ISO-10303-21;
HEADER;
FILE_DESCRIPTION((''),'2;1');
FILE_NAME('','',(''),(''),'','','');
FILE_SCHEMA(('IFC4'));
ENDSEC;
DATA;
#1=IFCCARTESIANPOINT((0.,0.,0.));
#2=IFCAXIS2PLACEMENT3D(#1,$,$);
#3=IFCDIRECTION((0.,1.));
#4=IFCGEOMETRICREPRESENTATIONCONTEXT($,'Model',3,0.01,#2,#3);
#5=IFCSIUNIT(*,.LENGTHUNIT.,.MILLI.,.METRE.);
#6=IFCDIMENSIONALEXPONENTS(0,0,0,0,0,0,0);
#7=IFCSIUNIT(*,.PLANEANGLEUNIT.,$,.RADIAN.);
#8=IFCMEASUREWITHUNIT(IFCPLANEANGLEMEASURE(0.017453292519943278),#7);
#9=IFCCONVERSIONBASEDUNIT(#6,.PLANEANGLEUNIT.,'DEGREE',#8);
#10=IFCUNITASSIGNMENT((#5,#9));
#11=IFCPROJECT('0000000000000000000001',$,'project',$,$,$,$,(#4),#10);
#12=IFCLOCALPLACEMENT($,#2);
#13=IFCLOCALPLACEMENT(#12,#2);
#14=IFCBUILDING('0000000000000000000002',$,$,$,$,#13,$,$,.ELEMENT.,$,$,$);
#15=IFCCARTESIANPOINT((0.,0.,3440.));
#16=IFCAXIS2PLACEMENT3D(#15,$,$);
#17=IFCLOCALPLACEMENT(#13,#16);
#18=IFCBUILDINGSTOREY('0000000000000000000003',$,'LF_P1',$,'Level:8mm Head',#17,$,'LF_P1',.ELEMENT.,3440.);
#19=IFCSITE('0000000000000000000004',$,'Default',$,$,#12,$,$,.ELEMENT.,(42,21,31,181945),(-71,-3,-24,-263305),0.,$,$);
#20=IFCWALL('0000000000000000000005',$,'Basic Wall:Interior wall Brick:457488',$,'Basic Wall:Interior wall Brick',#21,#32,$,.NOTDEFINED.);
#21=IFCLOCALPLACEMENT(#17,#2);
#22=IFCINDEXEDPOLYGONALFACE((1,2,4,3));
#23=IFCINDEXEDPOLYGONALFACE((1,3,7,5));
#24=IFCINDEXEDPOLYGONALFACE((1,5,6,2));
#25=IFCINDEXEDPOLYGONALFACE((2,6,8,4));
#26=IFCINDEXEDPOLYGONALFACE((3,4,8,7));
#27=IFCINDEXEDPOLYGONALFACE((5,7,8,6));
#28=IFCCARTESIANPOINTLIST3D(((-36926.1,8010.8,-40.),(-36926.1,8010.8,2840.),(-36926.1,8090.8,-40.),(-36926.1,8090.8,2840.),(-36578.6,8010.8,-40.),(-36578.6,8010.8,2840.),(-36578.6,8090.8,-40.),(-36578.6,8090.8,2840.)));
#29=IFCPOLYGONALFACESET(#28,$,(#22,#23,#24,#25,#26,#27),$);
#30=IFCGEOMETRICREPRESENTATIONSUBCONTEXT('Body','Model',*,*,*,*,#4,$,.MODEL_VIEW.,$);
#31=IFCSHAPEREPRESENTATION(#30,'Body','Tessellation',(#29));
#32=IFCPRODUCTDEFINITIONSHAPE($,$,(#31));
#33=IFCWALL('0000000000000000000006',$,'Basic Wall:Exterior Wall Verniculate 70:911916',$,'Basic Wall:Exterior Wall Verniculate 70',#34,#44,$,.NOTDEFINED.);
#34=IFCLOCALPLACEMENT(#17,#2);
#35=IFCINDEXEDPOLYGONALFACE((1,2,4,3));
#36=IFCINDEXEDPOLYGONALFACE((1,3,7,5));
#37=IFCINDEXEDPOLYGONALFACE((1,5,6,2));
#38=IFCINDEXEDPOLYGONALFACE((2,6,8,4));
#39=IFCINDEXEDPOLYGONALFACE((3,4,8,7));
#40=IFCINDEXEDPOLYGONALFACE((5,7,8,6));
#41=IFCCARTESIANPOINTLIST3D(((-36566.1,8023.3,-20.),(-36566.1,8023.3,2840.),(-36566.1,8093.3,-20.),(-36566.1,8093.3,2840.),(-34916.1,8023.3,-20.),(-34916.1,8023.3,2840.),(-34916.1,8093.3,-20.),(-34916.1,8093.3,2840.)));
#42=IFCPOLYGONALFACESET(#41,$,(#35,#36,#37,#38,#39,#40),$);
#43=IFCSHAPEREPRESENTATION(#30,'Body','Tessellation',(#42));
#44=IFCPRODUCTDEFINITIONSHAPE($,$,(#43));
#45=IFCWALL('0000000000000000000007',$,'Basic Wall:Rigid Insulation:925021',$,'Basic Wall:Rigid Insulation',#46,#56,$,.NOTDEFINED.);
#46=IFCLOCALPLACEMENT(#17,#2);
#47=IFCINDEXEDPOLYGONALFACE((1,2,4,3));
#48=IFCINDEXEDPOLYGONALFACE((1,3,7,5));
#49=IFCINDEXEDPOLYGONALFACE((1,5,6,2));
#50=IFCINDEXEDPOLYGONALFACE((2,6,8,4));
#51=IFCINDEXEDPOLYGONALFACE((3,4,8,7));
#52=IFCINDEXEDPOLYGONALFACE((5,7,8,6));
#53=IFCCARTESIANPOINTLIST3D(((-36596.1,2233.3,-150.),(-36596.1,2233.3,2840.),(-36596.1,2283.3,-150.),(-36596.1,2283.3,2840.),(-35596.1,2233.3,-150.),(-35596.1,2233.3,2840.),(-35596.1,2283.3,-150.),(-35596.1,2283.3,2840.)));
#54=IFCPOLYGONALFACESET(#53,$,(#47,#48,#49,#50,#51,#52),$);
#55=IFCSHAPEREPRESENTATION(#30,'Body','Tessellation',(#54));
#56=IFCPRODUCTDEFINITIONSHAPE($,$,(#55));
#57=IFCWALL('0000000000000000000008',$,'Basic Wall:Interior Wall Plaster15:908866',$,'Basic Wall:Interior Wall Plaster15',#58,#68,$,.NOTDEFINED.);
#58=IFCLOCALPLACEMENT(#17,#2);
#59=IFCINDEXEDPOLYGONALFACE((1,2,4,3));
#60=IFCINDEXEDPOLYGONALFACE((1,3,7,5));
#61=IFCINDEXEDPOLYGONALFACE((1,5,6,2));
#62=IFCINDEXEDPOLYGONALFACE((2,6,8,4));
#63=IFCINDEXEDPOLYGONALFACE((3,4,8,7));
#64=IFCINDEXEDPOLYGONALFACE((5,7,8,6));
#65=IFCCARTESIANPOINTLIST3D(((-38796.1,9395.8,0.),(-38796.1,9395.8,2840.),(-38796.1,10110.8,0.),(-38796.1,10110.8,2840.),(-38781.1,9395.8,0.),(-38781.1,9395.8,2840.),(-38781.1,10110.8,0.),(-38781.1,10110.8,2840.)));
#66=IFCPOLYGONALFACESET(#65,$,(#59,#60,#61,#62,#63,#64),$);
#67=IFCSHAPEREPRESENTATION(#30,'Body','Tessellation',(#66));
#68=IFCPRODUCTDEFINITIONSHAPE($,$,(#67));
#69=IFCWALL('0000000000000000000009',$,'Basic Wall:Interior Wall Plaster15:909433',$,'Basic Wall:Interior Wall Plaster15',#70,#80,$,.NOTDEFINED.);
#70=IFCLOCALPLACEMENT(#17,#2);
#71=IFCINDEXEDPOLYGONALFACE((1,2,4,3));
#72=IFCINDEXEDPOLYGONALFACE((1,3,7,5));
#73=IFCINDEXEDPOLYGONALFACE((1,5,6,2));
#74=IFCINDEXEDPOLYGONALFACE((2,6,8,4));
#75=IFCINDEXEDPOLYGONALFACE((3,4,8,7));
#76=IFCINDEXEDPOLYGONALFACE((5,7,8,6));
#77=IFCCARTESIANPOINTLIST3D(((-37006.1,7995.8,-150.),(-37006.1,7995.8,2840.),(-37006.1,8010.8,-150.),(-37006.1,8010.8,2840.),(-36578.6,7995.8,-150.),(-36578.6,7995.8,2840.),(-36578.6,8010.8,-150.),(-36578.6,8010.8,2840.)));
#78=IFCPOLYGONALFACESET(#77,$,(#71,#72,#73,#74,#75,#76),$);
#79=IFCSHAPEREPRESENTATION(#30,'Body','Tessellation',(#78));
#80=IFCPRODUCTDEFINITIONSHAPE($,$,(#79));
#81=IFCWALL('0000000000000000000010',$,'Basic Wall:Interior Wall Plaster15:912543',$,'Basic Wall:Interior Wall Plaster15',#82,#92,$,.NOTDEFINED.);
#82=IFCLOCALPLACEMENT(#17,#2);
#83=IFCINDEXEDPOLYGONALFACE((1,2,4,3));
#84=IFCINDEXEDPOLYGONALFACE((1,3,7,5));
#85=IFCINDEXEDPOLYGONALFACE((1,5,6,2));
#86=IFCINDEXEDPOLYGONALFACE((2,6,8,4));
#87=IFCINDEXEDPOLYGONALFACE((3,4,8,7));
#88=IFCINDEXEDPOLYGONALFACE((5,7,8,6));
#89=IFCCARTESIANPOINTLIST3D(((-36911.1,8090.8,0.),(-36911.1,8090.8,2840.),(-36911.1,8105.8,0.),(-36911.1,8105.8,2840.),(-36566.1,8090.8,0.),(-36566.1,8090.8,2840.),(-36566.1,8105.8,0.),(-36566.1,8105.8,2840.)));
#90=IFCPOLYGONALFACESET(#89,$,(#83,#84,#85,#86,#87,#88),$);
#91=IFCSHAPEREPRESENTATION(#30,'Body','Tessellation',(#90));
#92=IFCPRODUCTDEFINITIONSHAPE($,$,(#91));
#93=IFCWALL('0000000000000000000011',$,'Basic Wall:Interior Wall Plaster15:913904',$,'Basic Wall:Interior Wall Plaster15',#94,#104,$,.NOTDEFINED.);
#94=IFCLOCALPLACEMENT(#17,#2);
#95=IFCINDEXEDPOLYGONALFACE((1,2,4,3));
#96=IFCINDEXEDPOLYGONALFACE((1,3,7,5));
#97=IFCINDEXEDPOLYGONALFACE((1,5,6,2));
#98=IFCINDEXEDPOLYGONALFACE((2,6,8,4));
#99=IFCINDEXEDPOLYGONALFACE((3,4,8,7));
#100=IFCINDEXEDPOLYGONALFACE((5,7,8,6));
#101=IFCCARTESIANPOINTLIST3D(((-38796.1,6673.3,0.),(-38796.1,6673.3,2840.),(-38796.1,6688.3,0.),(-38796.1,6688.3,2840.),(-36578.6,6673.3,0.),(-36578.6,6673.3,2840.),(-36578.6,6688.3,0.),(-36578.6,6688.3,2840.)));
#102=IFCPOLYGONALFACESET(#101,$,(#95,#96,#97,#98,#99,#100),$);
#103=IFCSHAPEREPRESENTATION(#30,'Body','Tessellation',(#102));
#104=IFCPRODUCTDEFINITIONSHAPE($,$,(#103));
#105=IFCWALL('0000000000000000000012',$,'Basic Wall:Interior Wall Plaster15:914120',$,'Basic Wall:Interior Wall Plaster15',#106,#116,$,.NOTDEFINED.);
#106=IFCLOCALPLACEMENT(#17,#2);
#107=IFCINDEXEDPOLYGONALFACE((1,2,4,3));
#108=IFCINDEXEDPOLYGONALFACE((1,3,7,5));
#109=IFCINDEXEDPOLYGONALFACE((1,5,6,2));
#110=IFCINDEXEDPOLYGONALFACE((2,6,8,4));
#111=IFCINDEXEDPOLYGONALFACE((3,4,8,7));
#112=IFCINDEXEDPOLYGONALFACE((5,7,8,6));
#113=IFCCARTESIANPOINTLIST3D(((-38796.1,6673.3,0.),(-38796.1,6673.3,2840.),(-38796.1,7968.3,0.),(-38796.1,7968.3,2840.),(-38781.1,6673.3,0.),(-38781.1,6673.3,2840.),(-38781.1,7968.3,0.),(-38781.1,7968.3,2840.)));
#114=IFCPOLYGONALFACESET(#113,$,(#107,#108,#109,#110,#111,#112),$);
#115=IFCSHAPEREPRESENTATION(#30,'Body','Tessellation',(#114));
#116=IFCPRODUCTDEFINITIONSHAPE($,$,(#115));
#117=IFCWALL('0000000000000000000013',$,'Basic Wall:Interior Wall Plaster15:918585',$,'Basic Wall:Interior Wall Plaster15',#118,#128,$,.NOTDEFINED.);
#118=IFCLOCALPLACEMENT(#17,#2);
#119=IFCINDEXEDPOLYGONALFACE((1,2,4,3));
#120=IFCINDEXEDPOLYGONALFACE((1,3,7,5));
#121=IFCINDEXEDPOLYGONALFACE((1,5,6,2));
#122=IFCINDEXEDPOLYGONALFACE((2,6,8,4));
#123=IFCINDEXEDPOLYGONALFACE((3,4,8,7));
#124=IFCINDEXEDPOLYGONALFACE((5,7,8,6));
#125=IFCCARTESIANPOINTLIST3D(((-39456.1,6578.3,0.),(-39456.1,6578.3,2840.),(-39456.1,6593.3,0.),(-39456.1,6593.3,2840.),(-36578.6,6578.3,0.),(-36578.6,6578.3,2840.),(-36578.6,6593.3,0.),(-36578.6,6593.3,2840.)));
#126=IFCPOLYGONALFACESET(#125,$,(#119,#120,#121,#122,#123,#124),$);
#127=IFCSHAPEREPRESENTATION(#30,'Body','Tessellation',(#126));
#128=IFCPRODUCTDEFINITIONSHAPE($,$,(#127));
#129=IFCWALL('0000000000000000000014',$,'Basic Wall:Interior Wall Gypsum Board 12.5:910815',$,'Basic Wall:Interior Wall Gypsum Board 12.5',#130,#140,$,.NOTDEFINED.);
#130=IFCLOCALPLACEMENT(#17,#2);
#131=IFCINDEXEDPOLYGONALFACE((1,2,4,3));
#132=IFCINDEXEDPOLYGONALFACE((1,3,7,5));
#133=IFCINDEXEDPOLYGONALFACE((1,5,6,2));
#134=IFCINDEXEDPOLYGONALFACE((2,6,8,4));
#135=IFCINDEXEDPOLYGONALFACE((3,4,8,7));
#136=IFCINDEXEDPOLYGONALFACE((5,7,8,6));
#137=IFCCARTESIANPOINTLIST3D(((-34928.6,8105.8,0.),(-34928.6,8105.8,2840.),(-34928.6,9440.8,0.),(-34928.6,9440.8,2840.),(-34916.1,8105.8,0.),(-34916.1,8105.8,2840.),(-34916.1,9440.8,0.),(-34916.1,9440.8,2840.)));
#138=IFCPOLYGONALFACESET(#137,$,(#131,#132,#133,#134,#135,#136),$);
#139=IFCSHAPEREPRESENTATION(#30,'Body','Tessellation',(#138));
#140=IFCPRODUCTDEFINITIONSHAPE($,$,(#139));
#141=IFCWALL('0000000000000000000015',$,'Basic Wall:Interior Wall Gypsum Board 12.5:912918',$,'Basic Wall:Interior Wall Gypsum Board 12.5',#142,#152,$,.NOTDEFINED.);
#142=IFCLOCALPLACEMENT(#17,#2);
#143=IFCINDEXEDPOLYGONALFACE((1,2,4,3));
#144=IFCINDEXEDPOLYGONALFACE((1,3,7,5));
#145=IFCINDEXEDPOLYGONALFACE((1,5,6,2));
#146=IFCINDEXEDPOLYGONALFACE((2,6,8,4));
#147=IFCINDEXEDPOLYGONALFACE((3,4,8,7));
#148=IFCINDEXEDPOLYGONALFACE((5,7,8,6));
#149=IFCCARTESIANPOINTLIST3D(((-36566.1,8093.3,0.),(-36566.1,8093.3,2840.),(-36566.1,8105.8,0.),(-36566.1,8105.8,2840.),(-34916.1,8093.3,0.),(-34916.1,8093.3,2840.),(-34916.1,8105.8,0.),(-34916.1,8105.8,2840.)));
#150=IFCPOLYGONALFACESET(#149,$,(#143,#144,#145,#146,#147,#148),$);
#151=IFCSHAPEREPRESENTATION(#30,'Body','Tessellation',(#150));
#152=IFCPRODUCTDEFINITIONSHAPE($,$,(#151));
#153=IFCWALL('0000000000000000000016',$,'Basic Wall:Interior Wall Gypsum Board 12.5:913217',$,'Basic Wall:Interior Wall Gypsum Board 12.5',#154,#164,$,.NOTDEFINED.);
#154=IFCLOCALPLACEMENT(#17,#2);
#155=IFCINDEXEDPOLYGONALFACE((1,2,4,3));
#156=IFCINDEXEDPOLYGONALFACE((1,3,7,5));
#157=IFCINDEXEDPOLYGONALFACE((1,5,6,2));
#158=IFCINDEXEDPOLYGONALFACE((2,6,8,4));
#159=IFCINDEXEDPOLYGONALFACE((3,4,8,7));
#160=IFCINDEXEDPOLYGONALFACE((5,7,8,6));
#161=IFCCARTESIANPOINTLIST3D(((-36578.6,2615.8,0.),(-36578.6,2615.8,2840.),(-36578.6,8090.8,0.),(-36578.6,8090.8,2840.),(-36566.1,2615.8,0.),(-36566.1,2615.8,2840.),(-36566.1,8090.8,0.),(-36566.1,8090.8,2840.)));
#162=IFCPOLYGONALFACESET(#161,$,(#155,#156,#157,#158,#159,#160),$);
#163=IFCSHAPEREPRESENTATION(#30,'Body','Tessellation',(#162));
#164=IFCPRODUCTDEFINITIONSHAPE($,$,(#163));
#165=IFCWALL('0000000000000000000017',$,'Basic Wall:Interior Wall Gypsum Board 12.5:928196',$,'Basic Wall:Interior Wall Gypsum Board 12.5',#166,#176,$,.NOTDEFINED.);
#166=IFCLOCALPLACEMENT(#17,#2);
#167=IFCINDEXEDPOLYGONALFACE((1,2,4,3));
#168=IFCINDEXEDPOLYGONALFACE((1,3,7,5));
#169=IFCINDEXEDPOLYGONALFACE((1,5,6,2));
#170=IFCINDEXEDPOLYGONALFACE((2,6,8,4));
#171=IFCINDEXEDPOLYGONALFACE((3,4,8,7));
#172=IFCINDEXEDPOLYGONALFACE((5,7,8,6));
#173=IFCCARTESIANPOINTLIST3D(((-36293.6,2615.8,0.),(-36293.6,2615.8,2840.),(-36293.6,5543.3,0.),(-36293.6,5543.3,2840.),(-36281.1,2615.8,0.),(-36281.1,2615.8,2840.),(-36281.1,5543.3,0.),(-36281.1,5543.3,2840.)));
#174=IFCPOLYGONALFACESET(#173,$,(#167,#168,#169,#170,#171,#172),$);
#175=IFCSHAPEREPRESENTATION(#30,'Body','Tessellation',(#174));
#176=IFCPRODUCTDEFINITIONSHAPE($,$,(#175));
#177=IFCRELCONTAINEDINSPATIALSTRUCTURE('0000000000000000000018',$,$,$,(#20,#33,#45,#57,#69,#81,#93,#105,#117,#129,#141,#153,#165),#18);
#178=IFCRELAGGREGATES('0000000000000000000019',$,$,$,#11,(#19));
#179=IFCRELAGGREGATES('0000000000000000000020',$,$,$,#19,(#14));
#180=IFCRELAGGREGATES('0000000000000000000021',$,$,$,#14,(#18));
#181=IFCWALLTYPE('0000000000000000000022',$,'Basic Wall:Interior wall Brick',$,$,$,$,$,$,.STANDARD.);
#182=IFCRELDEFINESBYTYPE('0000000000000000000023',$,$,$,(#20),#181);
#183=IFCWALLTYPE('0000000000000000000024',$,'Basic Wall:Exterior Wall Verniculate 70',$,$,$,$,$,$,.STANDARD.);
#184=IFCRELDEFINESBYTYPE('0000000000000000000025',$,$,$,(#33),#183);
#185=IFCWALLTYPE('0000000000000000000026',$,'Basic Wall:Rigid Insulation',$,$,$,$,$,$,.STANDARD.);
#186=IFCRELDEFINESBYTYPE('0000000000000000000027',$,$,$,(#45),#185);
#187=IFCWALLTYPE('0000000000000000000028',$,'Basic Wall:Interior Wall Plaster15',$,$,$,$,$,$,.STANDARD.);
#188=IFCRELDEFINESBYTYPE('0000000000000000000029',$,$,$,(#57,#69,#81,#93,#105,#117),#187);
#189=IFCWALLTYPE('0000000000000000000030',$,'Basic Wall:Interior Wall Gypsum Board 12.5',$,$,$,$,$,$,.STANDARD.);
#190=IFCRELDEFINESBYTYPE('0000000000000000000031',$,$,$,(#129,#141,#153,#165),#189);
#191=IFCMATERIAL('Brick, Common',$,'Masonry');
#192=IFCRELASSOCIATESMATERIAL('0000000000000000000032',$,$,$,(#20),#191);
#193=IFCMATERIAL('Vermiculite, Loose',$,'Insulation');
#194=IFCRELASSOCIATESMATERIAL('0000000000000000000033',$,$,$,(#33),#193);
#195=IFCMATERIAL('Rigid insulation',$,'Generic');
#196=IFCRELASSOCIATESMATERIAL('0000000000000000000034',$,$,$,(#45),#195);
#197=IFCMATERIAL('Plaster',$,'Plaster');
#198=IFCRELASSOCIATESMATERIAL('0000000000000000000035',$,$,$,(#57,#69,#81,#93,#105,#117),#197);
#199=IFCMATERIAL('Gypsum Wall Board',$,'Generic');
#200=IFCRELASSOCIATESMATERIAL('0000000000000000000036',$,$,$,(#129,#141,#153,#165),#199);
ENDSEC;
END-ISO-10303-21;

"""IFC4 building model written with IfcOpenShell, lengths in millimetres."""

from ifc_helpers import new_model, entity, si_unit, converted_unit, direction, frame, origin, place, context, subcontext, project, spatial, indexed_curve, outline, extrude, material, type_object, element, save


model = new_model("IFC4")

# Units and contexts
model_context = context("Model", 3, precision=0.01, world=origin(), true_north=direction((0.0, 1.0)))
body_context = subcontext(model_context, "Body", "Model", "MODEL_VIEW")
ifc_project = project(units=[si_unit("LENGTHUNIT", "METRE", prefix="MILLI"), converted_unit("PLANEANGLEUNIT", "DEGREE", entity("IfcPlaneAngleMeasure", 0.017453292519943278), si_unit("PLANEANGLEUNIT", "RADIAN"), dimensions=[0, 0, 0, 0, 0, 0, 0])], contexts=[model_context])

# Site, building, storey
site_placement = place(None, origin())
site = spatial("IfcSite", under=ifc_project, at=site_placement, Name="Default", CompositionType="ELEMENT", RefLatitude=(42, 21, 31, 181945), RefLongitude=(-71, -3, -24, -263305), RefElevation=0.0)
building_placement = place(site_placement, origin())
building = spatial("IfcBuilding", under=site, at=building_placement, CompositionType="ELEMENT")
storey_placement = place(building_placement, frame((0.0, 0.0, 3440.0)))
storey = spatial("IfcBuildingStorey", under=building, at=storey_placement, Name="LF_P1", ObjectType="Level:8mm Head", LongName="LF_P1", CompositionType="ELEMENT", Elevation=3440.0)

# Walls
ifc_material_1 = material(Name="Brick, Common", Category="Masonry")
wall_type_1 = type_object("IfcWallType", Name="Basic Wall:Interior wall Brick", PredefinedType="STANDARD")
wall_1_placement = place(storey_placement, frame((-36926.1, 8050.8, -40.0)))
element("IfcWall", 1, at=wall_1_placement, inside=storey, type_object=wall_type_1, material=ifc_material_1, Name="Basic Wall:Interior wall Brick:457488", ObjectType="Basic Wall:Interior wall Brick", PredefinedType="NOTDEFINED", context=body_context, shape_type="SweptSolid", body=[
    extrude(outline(indexed_curve([(347.5, 40.0), (0.0, 40.0), (0.0, -40.0), (347.5, -40.0), (347.5, 40.0)], self_intersect=False)), origin(), (0.0, 0.0, 1.0), 2880.0),
])
ifc_material_2 = material(Name="Vermiculite, Loose", Category="Insulation")
wall_type_2 = type_object("IfcWallType", Name="Basic Wall:Exterior Wall Verniculate 70", PredefinedType="STANDARD")
wall_2_placement = place(storey_placement, frame((-34916.1, 8058.3, -20.0), z_axis=(0.0, 0.0, 1.0), x_axis=(-1.0, 0.0, 0.0)))
element("IfcWall", 2, at=wall_2_placement, inside=storey, type_object=wall_type_2, material=ifc_material_2, Name="Basic Wall:Exterior Wall Verniculate 70:911916", ObjectType="Basic Wall:Exterior Wall Verniculate 70", PredefinedType="NOTDEFINED", context=body_context, shape_type="SweptSolid", body=[
    extrude(outline(indexed_curve([(1650.0, 35.0), (0.0, 35.0), (0.0, -35.0), (1650.0, -35.0), (1650.0, 35.0)], self_intersect=False)), origin(), (0.0, 0.0, 1.0), 2860.0),
])
ifc_material_3 = material(Name="Rigid insulation", Category="Generic")
wall_type_3 = type_object("IfcWallType", Name="Basic Wall:Rigid Insulation", PredefinedType="STANDARD")
wall_3_placement = place(storey_placement, frame((-35596.1, 2258.3, -150.0), z_axis=(0.0, 0.0, 1.0), x_axis=(-1.0, 0.0, 0.0)))
element("IfcWall", 3, at=wall_3_placement, inside=storey, type_object=wall_type_3, material=ifc_material_3, Name="Basic Wall:Rigid Insulation:925021", ObjectType="Basic Wall:Rigid Insulation", PredefinedType="NOTDEFINED", context=body_context, shape_type="SweptSolid", body=[
    extrude(outline(indexed_curve([(1000.0, 25.0), (0.0, 25.0), (0.0, -25.0), (1000.0, -25.0), (1000.0, 25.0)], self_intersect=False)), origin(), (0.0, 0.0, 1.0), 2990.0),
])
ifc_material_4 = material(Name="Plaster", Category="Plaster")
wall_type_4 = type_object("IfcWallType", Name="Basic Wall:Interior Wall Plaster15", PredefinedType="STANDARD")
wall_4_placement = place(storey_placement, frame((-38788.6, 9395.8, 0.0), z_axis=(0.0, 0.0, 1.0), x_axis=(0.0, 1.0, 0.0)))
element("IfcWall", 4, at=wall_4_placement, inside=storey, type_object=wall_type_4, material=ifc_material_4, Name="Basic Wall:Interior Wall Plaster15:908866", ObjectType="Basic Wall:Interior Wall Plaster15", PredefinedType="NOTDEFINED", context=body_context, shape_type="SweptSolid", body=[
    extrude(outline(indexed_curve([(715.0, 7.5), (0.0, 7.5), (0.0, -7.5), (715.0, -7.5), (715.0, 7.5)], self_intersect=False)), origin(), (0.0, 0.0, 1.0), 2840.0),
])
wall_5_placement = place(storey_placement, frame((-37006.1, 8003.3, -150.0)))
element("IfcWall", 5, at=wall_5_placement, inside=storey, type_object=wall_type_4, material=ifc_material_4, Name="Basic Wall:Interior Wall Plaster15:909433", ObjectType="Basic Wall:Interior Wall Plaster15", PredefinedType="NOTDEFINED", context=body_context, shape_type="SweptSolid", body=[
    extrude(outline(indexed_curve([(427.5, 7.5), (0.0, 7.5), (0.0, -7.5), (427.5, -7.5), (427.5, 7.5)], self_intersect=False)), origin(), (0.0, 0.0, 1.0), 2990.0),
])
wall_6_placement = place(storey_placement, frame((-36911.1, 8098.3, 0.0)))
element("IfcWall", 6, at=wall_6_placement, inside=storey, type_object=wall_type_4, material=ifc_material_4, Name="Basic Wall:Interior Wall Plaster15:912543", ObjectType="Basic Wall:Interior Wall Plaster15", PredefinedType="NOTDEFINED", context=body_context, shape_type="SweptSolid", body=[
    extrude(outline(indexed_curve([(345.0, 7.5), (0.0, 7.5), (0.0, -7.5), (345.0, -7.5), (345.0, 7.5)], self_intersect=False)), origin(), (0.0, 0.0, 1.0), 2840.0),
])
wall_7_placement = place(storey_placement, frame((-36578.6, 6680.8, 0.0), z_axis=(0.0, 0.0, 1.0), x_axis=(-1.0, 0.0, 0.0)))
element("IfcWall", 7, at=wall_7_placement, inside=storey, type_object=wall_type_4, material=ifc_material_4, Name="Basic Wall:Interior Wall Plaster15:913904", ObjectType="Basic Wall:Interior Wall Plaster15", PredefinedType="NOTDEFINED", context=body_context, shape_type="SweptSolid", body=[
    extrude(outline(indexed_curve([(2217.5, 7.5), (0.0, 7.5), (0.0, -7.5), (2217.5, -7.5), (2217.5, 7.5)], self_intersect=False)), origin(), (0.0, 0.0, 1.0), 2840.0),
])
wall_8_placement = place(storey_placement, frame((-38788.6, 6673.3, 0.0), z_axis=(0.0, 0.0, 1.0), x_axis=(0.0, 1.0, 0.0)))
element("IfcWall", 8, at=wall_8_placement, inside=storey, type_object=wall_type_4, material=ifc_material_4, Name="Basic Wall:Interior Wall Plaster15:914120", ObjectType="Basic Wall:Interior Wall Plaster15", PredefinedType="NOTDEFINED", context=body_context, shape_type="SweptSolid", body=[
    extrude(outline(indexed_curve([(1295.0, 7.5), (0.0, 7.5), (0.0, -7.5), (1295.0, -7.5), (1295.0, 7.5)], self_intersect=False)), origin(), (0.0, 0.0, 1.0), 2840.0),
])
wall_9_placement = place(storey_placement, frame((-36578.6, 6585.8, 0.0), z_axis=(0.0, 0.0, 1.0), x_axis=(-1.0, 0.0, 0.0)))
element("IfcWall", 9, at=wall_9_placement, inside=storey, type_object=wall_type_4, material=ifc_material_4, Name="Basic Wall:Interior Wall Plaster15:918585", ObjectType="Basic Wall:Interior Wall Plaster15", PredefinedType="NOTDEFINED", context=body_context, shape_type="SweptSolid", body=[
    extrude(outline(indexed_curve([(2877.5, 7.5), (0.0, 7.5), (0.0, -7.5), (2877.5, -7.5), (2877.5, 7.5)], self_intersect=False)), origin(), (0.0, 0.0, 1.0), 2840.0),
])
ifc_material_5 = material(Name="Gypsum Wall Board", Category="Generic")
wall_type_5 = type_object("IfcWallType", Name="Basic Wall:Interior Wall Gypsum Board 12.5", PredefinedType="STANDARD")
wall_10_placement = place(storey_placement, frame((-34922.4, 9440.8, 0.0), z_axis=(0.0, 0.0, 1.0), x_axis=(0.0, -1.0, 0.0)))
element("IfcWall", 10, at=wall_10_placement, inside=storey, type_object=wall_type_5, material=ifc_material_5, Name="Basic Wall:Interior Wall Gypsum Board 12.5:910815", ObjectType="Basic Wall:Interior Wall Gypsum Board 12.5", PredefinedType="NOTDEFINED", context=body_context, shape_type="SweptSolid", body=[
    extrude(outline(indexed_curve([(1335.0, 6.2), (0.0, 6.2), (0.0, -6.2), (1335.0, -6.2), (1335.0, 6.2)], self_intersect=False)), origin(), (0.0, 0.0, 1.0), 2840.0),
])
wall_11_placement = place(storey_placement, frame((-36566.1, 8099.6, 0.0)))
element("IfcWall", 11, at=wall_11_placement, inside=storey, type_object=wall_type_5, material=ifc_material_5, Name="Basic Wall:Interior Wall Gypsum Board 12.5:912918", ObjectType="Basic Wall:Interior Wall Gypsum Board 12.5", PredefinedType="NOTDEFINED", context=body_context, shape_type="SweptSolid", body=[
    extrude(outline(indexed_curve([(1650.0, 6.2), (0.0, 6.2), (0.0, -6.2), (1650.0, -6.2), (1650.0, 6.2)], self_intersect=False)), origin(), (0.0, 0.0, 1.0), 2840.0),
])
wall_12_placement = place(storey_placement, frame((-36572.4, 8090.8, 0.0), z_axis=(0.0, 0.0, 1.0), x_axis=(0.0, -1.0, 0.0)))
element("IfcWall", 12, at=wall_12_placement, inside=storey, type_object=wall_type_5, material=ifc_material_5, Name="Basic Wall:Interior Wall Gypsum Board 12.5:913217", ObjectType="Basic Wall:Interior Wall Gypsum Board 12.5", PredefinedType="NOTDEFINED", context=body_context, shape_type="SweptSolid", body=[
    extrude(outline(indexed_curve([(5475.0, 6.2), (0.0, 6.2), (0.0, -6.2), (5475.0, -6.2), (5475.0, 6.2)], self_intersect=False)), origin(), (0.0, 0.0, 1.0), 2840.0),
])
wall_13_placement = place(storey_placement, frame((-36287.4, 2615.8, 0.0), z_axis=(0.0, 0.0, 1.0), x_axis=(0.0, 1.0, 0.0)))
element("IfcWall", 13, at=wall_13_placement, inside=storey, type_object=wall_type_5, material=ifc_material_5, Name="Basic Wall:Interior Wall Gypsum Board 12.5:928196", ObjectType="Basic Wall:Interior Wall Gypsum Board 12.5", PredefinedType="NOTDEFINED", context=body_context, shape_type="SweptSolid", body=[
    extrude(outline(indexed_curve([(2927.5, 6.2), (0.0, 6.2), (0.0, -6.2), (2927.5, -6.2), (2927.5, 6.2)], self_intersect=False)), origin(), (0.0, 0.0, 1.0), 2840.0),
])

save(model, "model.ifc")
